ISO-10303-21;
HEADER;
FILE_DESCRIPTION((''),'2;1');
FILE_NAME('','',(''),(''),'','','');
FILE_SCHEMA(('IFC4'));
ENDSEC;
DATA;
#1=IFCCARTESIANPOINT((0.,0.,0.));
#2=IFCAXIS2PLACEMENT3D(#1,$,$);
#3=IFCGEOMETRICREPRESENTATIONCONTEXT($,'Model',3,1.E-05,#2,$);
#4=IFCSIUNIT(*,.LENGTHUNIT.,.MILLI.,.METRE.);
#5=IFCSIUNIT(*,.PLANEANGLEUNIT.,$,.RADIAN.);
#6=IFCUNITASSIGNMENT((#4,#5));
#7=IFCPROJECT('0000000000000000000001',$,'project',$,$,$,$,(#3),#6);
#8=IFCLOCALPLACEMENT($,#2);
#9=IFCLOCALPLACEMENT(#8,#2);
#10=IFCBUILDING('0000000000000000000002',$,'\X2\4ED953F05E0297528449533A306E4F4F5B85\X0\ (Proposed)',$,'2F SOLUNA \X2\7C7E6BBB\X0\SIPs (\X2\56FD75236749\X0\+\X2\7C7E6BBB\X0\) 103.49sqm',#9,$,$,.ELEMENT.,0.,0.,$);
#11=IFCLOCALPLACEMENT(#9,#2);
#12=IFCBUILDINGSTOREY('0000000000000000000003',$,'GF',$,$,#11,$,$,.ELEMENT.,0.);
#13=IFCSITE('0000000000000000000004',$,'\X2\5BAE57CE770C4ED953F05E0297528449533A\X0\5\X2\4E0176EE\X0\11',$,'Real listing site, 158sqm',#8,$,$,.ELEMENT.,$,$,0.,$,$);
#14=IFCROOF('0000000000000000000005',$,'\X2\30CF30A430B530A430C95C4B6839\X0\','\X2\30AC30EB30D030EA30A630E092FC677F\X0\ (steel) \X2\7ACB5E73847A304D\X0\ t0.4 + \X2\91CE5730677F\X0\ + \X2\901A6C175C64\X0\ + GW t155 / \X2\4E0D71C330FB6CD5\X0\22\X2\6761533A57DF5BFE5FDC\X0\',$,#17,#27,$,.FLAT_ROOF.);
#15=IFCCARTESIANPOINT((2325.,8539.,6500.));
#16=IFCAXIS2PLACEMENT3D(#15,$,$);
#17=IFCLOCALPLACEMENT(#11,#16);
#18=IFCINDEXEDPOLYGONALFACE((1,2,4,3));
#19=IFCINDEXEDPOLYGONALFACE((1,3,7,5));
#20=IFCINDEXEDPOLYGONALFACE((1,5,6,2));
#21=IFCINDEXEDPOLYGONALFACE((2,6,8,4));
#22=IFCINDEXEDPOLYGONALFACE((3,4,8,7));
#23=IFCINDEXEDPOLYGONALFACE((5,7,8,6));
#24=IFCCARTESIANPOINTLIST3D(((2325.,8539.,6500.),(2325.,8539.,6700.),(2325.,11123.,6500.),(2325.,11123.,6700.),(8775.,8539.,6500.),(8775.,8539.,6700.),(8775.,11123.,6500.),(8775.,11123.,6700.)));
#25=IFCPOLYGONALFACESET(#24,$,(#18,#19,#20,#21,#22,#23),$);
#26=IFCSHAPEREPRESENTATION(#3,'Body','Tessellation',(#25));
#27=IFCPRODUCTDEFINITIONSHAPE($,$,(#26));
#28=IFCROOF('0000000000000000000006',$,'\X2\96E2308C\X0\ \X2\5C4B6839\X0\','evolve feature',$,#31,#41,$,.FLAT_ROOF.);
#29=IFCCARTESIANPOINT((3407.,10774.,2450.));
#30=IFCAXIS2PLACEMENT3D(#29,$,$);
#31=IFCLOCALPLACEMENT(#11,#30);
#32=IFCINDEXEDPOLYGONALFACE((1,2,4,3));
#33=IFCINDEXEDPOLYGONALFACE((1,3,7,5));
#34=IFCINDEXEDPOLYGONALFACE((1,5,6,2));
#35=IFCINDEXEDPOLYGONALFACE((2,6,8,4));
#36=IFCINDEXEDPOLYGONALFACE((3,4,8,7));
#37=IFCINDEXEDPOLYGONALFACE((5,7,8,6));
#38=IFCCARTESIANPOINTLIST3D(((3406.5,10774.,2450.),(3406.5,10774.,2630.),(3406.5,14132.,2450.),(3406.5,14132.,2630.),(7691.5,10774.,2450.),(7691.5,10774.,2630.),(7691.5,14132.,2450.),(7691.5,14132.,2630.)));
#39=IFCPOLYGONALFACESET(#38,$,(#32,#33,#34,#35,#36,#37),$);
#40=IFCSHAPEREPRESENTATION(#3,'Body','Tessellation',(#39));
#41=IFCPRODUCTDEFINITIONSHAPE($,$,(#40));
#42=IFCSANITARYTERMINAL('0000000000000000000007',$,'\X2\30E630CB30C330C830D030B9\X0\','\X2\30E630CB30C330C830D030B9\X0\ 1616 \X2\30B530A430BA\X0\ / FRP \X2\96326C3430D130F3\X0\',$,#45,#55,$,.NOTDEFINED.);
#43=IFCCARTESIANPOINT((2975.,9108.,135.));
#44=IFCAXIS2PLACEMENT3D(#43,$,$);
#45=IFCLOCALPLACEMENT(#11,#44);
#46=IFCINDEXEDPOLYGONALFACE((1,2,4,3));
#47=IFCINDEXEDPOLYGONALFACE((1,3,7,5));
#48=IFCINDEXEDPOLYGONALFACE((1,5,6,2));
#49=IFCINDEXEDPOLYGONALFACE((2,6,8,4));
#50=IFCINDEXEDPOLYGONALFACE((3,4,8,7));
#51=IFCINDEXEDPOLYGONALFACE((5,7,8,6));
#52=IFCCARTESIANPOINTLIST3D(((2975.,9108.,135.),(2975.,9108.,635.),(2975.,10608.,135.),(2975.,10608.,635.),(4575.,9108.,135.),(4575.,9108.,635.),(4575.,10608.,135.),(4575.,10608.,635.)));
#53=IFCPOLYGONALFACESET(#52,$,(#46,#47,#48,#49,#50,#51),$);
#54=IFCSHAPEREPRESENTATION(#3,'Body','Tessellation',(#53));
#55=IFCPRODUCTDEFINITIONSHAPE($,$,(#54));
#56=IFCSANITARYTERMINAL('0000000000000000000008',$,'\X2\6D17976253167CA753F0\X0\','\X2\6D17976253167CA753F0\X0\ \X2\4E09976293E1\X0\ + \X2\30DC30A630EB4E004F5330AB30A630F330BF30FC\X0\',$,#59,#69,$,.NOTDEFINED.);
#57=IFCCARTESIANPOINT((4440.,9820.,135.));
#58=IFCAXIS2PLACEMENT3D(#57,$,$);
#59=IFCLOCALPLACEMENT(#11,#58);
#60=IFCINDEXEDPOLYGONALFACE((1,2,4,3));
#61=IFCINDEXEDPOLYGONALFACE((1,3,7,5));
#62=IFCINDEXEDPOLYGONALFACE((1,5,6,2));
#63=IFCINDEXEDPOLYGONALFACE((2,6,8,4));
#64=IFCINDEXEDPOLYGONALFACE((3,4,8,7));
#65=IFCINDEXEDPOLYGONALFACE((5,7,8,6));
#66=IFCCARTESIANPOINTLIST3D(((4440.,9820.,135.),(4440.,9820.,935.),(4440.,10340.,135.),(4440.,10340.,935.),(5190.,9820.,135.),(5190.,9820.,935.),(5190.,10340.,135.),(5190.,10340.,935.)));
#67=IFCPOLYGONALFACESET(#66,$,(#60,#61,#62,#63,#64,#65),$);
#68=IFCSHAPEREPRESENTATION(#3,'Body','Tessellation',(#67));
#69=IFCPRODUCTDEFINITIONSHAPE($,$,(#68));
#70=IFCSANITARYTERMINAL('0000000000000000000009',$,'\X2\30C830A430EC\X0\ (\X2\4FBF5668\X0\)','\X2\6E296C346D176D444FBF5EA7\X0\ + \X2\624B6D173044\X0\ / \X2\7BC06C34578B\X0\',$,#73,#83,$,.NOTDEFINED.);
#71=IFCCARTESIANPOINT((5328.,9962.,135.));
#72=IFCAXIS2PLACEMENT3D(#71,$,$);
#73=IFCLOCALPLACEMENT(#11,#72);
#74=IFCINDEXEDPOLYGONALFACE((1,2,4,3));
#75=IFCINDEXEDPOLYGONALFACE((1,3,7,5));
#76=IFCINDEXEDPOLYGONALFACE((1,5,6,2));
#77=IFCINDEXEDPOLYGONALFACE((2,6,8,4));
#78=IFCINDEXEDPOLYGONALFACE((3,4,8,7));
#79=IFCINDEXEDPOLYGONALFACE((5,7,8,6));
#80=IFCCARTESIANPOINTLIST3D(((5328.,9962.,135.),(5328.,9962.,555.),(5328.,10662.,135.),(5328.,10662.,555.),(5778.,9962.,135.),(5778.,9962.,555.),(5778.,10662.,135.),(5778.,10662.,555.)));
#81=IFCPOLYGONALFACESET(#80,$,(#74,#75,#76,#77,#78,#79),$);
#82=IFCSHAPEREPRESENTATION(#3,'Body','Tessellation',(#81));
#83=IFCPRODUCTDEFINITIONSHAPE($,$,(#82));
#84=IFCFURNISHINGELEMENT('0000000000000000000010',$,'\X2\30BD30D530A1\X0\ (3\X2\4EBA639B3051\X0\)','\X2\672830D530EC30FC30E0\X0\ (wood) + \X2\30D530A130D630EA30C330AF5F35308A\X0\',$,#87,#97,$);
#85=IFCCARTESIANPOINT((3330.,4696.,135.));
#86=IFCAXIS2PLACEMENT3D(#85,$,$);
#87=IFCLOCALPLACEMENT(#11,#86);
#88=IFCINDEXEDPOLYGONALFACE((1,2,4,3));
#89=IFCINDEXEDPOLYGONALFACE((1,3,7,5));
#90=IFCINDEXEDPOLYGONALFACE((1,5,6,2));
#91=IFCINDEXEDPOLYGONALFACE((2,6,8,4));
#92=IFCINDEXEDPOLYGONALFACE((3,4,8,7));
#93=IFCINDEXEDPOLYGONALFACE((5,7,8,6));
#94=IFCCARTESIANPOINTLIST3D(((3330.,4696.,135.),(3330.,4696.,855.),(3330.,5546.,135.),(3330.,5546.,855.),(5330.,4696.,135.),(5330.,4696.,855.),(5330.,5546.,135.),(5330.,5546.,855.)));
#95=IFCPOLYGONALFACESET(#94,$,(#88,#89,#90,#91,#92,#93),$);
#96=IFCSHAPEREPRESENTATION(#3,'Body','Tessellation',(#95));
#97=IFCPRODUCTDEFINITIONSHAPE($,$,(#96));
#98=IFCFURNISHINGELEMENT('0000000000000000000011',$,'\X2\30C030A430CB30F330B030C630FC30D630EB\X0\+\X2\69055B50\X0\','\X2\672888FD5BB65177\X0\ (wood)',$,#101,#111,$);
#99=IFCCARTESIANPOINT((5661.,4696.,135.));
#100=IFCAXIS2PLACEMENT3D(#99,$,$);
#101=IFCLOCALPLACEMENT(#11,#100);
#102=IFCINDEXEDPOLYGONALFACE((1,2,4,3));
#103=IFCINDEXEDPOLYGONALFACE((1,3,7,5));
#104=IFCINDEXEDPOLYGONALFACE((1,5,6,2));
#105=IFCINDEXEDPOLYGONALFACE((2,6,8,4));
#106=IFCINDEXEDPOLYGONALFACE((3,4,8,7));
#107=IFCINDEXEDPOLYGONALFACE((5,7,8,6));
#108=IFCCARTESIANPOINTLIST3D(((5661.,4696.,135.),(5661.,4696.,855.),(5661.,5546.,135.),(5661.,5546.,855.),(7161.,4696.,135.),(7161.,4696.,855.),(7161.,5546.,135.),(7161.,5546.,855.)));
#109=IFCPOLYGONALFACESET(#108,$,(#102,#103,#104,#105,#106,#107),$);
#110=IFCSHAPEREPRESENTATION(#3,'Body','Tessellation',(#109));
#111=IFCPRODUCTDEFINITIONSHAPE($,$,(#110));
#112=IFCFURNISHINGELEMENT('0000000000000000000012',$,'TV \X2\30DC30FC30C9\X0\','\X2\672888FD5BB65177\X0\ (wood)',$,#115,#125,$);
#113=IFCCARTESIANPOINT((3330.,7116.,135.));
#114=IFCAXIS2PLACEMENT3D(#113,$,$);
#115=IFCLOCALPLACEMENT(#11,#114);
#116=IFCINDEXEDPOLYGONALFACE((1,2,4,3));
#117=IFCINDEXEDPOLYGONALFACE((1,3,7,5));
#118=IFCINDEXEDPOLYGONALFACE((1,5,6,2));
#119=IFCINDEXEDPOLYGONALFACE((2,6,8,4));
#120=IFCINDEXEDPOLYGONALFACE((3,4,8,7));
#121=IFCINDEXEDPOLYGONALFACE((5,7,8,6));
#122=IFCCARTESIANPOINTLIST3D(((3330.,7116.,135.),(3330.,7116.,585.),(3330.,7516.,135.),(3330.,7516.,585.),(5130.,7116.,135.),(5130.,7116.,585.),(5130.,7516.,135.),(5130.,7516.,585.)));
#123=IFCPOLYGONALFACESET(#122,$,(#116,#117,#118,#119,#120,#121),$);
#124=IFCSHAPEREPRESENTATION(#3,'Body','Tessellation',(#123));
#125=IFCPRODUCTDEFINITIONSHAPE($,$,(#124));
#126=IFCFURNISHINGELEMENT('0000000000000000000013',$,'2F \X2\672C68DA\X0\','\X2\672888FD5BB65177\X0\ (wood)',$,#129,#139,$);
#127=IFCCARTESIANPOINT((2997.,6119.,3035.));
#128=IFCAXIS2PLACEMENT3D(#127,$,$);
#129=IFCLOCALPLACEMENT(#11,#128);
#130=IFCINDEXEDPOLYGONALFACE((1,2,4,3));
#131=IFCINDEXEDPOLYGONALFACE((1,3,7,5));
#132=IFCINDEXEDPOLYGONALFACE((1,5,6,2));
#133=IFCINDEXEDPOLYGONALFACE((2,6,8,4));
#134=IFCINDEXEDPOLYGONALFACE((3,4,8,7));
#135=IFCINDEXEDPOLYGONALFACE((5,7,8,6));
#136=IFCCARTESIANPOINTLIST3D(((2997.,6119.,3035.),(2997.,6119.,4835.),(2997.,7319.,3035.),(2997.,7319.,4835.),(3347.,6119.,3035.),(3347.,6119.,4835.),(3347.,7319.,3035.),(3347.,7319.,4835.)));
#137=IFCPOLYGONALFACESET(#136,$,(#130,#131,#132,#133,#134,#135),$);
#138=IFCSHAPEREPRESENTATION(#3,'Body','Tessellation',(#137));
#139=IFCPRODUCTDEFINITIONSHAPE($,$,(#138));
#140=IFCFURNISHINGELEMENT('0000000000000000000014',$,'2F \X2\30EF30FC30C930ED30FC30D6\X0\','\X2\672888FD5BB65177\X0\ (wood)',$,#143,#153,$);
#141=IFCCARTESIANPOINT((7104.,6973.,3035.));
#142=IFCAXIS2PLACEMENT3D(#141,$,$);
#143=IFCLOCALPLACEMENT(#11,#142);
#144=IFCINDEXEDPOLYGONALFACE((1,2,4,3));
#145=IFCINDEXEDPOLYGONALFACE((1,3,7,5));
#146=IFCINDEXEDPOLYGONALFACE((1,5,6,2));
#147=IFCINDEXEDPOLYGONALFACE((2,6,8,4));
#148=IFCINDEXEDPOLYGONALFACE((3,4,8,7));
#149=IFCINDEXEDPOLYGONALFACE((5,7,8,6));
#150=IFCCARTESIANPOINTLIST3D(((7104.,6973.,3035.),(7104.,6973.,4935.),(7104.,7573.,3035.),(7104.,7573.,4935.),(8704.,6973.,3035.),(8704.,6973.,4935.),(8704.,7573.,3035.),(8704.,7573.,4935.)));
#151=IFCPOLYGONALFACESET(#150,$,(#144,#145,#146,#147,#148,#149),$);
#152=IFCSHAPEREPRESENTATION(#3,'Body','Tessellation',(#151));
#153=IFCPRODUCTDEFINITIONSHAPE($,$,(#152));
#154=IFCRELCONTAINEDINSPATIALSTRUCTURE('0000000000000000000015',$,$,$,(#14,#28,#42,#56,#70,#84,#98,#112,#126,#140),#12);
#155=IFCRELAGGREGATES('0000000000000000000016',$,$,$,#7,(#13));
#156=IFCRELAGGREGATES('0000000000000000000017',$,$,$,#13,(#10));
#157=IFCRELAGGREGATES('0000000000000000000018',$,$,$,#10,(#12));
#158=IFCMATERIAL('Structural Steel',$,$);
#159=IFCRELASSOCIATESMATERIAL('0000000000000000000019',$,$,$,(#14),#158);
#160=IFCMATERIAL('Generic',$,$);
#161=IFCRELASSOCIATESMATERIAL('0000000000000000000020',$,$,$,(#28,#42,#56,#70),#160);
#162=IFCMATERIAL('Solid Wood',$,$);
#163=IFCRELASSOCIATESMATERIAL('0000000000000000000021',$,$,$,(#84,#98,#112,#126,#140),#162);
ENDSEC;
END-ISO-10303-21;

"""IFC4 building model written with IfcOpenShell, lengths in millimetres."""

from ifc_helpers import new_model, si_unit, frame, frame_2d, origin, place, context, project, spatial, rectangle, extrude, material, element, save


model = new_model("IFC4")

# Units and contexts
model_context = context("Model", 3, precision=1e-05, world=origin())
ifc_project = project(units=[si_unit("LENGTHUNIT", "METRE", prefix="MILLI"), si_unit("PLANEANGLEUNIT", "RADIAN")], contexts=[model_context])

# Site, building, storey
site_placement = place(None, origin())
site = spatial("IfcSite", under=ifc_project, at=site_placement, Name="宮城県仙台市青葉区5丁目11", ObjectType="Real listing site, 158sqm", CompositionType="ELEMENT", RefElevation=0.0)
building_placement = place(site_placement, origin())
building = spatial("IfcBuilding", under=site, at=building_placement, Name="仙台市青葉区の住宅 (Proposed)", ObjectType="2F SOLUNA 籾殻SIPs (国産杉+籾殻) 103.49sqm", CompositionType="ELEMENT", ElevationOfRefHeight=0.0, ElevationOfTerrain=0.0)
storey_placement = place(building_placement, origin())
storey = spatial("IfcBuildingStorey", under=building, at=storey_placement, Name="GF", CompositionType="ELEMENT", Elevation=0.0)

# Shared definitions
ifc_material_1 = material(Name="Generic")

# Shared definitions
ifc_material_2 = material(Name="Solid Wood")

# Roofs
ifc_material_3 = material(Name="Structural Steel")
roof_1_placement = place(storey_placement, frame((2325.0, 8539.0, 6500.0)))
element("IfcRoof", 1, at=roof_1_placement, inside=storey, material=ifc_material_3, Name="ハイサイド屋根", Description="ガルバリウム鋼板 (steel) 立平葺き t0.4 + 野地板 + 通気層 + GW t155 / 不燃・法22条区域対応", PredefinedType="FLAT_ROOF", context=model_context, shape_type="SweptSolid", body=[
    extrude(rectangle(XDim=6450.0, YDim=2584.0, at=frame_2d((3225.0, 1292.0))), frame((2325.0, 8539.0, 6500.0)), (0.0, 0.0, 1.0), 200.0),
])
roof_2_placement = place(storey_placement, frame((3407.0, 10774.0, 2450.0)))
element("IfcRoof", 2, at=roof_2_placement, inside=storey, material=ifc_material_1, Name="離れ 屋根", Description="evolve feature", PredefinedType="FLAT_ROOF", context=model_context, shape_type="SweptSolid", body=[
    extrude(rectangle(XDim=4285.0, YDim=3358.0, at=frame_2d((2142.0, 1679.0))), frame((3407.0, 10774.0, 2450.0)), (0.0, 0.0, 1.0), 180.0),
])

# Sanitary terminals
sanitary_terminal_1_placement = place(storey_placement, frame((2975.0, 9108.0, 135.0)))
element("IfcSanitaryTerminal", 3, at=sanitary_terminal_1_placement, inside=storey, material=ifc_material_1, Name="ユニットバス", Description="ユニットバス 1616 サイズ / FRP 防水パン", PredefinedType="NOTDEFINED", context=model_context, shape_type="SweptSolid", body=[
    extrude(rectangle(XDim=1600.0, YDim=1500.0, at=frame_2d((800.0, 750.0))), frame((2975.0, 9108.0, 135.0)), (0.0, 0.0, 1.0), 500.0),
])
sanitary_terminal_2_placement = place(storey_placement, frame((4440.0, 9820.0, 135.0)))
element("IfcSanitaryTerminal", 4, at=sanitary_terminal_2_placement, inside=storey, material=ifc_material_1, Name="洗面化粧台", Description="洗面化粧台 三面鏡 + ボウル一体カウンター", PredefinedType="NOTDEFINED", context=model_context, shape_type="SweptSolid", body=[
    extrude(rectangle(XDim=750.0, YDim=520.0, at=frame_2d((375.0, 260.0))), frame((4440.0, 9820.0, 135.0)), (0.0, 0.0, 1.0), 800.0),
])
sanitary_terminal_3_placement = place(storey_placement, frame((5328.0, 9962.0, 135.0)))
element("IfcSanitaryTerminal", 5, at=sanitary_terminal_3_placement, inside=storey, material=ifc_material_1, Name="トイレ (便器)", Description="温水洗浄便座 + 手洗い / 節水型", PredefinedType="NOTDEFINED", context=model_context, shape_type="SweptSolid", body=[
    extrude(rectangle(XDim=450.0, YDim=700.0, at=frame_2d((225.0, 350.0))), frame((5328.0, 9962.0, 135.0)), (0.0, 0.0, 1.0), 420.0),
])

# Furnishing elements
furnishing_1_placement = place(storey_placement, frame((3330.0, 4696.0, 135.0)))
element("IfcFurnishingElement", 6, at=furnishing_1_placement, inside=storey, material=ifc_material_2, Name="ソファ (3人掛け)", Description="木フレーム (wood) + ファブリック張り", context=model_context, shape_type="SweptSolid", body=[
    extrude(rectangle(XDim=2000.0, YDim=850.0, at=frame_2d((1000.0, 425.0))), frame((3330.0, 4696.0, 135.0)), (0.0, 0.0, 1.0), 720.0),
])
furnishing_2_placement = place(storey_placement, frame((5661.0, 4696.0, 135.0)))
element("IfcFurnishingElement", 7, at=furnishing_2_placement, inside=storey, material=ifc_material_2, Name="ダイニングテーブル+椅子", Description="木製家具 (wood)", context=model_context, shape_type="SweptSolid", body=[
    extrude(rectangle(XDim=1500.0, YDim=850.0, at=frame_2d((750.0, 425.0))), frame((5661.0, 4696.0, 135.0)), (0.0, 0.0, 1.0), 720.0),
])
furnishing_3_placement = place(storey_placement, frame((3330.0, 7116.0, 135.0)))
element("IfcFurnishingElement", 8, at=furnishing_3_placement, inside=storey, material=ifc_material_2, Name="TV ボード", Description="木製家具 (wood)", context=model_context, shape_type="SweptSolid", body=[
    extrude(rectangle(XDim=1800.0, YDim=400.0, at=frame_2d((900.0, 200.0))), frame((3330.0, 7116.0, 135.0)), (0.0, 0.0, 1.0), 450.0),
])
furnishing_4_placement = place(storey_placement, frame((2997.0, 6119.0, 3035.0)))
element("IfcFurnishingElement", 9, at=furnishing_4_placement, inside=storey, material=ifc_material_2, Name="2F 本棚", Description="木製家具 (wood)", context=model_context, shape_type="SweptSolid", body=[
    extrude(rectangle(XDim=350.0, YDim=1200.0, at=frame_2d((175.0, 600.0))), frame((2997.0, 6119.0, 3035.0)), (0.0, 0.0, 1.0), 1800.0),
])
furnishing_5_placement = place(storey_placement, frame((7104.0, 6973.0, 3035.0)))
element("IfcFurnishingElement", 10, at=furnishing_5_placement, inside=storey, material=ifc_material_2, Name="2F ワードローブ", Description="木製家具 (wood)", context=model_context, shape_type="SweptSolid", body=[
    extrude(rectangle(XDim=1600.0, YDim=600.0, at=frame_2d((800.0, 300.0))), frame((7104.0, 6973.0, 3035.0)), (0.0, 0.0, 1.0), 1900.0),
])

save(model, "model.ifc")
